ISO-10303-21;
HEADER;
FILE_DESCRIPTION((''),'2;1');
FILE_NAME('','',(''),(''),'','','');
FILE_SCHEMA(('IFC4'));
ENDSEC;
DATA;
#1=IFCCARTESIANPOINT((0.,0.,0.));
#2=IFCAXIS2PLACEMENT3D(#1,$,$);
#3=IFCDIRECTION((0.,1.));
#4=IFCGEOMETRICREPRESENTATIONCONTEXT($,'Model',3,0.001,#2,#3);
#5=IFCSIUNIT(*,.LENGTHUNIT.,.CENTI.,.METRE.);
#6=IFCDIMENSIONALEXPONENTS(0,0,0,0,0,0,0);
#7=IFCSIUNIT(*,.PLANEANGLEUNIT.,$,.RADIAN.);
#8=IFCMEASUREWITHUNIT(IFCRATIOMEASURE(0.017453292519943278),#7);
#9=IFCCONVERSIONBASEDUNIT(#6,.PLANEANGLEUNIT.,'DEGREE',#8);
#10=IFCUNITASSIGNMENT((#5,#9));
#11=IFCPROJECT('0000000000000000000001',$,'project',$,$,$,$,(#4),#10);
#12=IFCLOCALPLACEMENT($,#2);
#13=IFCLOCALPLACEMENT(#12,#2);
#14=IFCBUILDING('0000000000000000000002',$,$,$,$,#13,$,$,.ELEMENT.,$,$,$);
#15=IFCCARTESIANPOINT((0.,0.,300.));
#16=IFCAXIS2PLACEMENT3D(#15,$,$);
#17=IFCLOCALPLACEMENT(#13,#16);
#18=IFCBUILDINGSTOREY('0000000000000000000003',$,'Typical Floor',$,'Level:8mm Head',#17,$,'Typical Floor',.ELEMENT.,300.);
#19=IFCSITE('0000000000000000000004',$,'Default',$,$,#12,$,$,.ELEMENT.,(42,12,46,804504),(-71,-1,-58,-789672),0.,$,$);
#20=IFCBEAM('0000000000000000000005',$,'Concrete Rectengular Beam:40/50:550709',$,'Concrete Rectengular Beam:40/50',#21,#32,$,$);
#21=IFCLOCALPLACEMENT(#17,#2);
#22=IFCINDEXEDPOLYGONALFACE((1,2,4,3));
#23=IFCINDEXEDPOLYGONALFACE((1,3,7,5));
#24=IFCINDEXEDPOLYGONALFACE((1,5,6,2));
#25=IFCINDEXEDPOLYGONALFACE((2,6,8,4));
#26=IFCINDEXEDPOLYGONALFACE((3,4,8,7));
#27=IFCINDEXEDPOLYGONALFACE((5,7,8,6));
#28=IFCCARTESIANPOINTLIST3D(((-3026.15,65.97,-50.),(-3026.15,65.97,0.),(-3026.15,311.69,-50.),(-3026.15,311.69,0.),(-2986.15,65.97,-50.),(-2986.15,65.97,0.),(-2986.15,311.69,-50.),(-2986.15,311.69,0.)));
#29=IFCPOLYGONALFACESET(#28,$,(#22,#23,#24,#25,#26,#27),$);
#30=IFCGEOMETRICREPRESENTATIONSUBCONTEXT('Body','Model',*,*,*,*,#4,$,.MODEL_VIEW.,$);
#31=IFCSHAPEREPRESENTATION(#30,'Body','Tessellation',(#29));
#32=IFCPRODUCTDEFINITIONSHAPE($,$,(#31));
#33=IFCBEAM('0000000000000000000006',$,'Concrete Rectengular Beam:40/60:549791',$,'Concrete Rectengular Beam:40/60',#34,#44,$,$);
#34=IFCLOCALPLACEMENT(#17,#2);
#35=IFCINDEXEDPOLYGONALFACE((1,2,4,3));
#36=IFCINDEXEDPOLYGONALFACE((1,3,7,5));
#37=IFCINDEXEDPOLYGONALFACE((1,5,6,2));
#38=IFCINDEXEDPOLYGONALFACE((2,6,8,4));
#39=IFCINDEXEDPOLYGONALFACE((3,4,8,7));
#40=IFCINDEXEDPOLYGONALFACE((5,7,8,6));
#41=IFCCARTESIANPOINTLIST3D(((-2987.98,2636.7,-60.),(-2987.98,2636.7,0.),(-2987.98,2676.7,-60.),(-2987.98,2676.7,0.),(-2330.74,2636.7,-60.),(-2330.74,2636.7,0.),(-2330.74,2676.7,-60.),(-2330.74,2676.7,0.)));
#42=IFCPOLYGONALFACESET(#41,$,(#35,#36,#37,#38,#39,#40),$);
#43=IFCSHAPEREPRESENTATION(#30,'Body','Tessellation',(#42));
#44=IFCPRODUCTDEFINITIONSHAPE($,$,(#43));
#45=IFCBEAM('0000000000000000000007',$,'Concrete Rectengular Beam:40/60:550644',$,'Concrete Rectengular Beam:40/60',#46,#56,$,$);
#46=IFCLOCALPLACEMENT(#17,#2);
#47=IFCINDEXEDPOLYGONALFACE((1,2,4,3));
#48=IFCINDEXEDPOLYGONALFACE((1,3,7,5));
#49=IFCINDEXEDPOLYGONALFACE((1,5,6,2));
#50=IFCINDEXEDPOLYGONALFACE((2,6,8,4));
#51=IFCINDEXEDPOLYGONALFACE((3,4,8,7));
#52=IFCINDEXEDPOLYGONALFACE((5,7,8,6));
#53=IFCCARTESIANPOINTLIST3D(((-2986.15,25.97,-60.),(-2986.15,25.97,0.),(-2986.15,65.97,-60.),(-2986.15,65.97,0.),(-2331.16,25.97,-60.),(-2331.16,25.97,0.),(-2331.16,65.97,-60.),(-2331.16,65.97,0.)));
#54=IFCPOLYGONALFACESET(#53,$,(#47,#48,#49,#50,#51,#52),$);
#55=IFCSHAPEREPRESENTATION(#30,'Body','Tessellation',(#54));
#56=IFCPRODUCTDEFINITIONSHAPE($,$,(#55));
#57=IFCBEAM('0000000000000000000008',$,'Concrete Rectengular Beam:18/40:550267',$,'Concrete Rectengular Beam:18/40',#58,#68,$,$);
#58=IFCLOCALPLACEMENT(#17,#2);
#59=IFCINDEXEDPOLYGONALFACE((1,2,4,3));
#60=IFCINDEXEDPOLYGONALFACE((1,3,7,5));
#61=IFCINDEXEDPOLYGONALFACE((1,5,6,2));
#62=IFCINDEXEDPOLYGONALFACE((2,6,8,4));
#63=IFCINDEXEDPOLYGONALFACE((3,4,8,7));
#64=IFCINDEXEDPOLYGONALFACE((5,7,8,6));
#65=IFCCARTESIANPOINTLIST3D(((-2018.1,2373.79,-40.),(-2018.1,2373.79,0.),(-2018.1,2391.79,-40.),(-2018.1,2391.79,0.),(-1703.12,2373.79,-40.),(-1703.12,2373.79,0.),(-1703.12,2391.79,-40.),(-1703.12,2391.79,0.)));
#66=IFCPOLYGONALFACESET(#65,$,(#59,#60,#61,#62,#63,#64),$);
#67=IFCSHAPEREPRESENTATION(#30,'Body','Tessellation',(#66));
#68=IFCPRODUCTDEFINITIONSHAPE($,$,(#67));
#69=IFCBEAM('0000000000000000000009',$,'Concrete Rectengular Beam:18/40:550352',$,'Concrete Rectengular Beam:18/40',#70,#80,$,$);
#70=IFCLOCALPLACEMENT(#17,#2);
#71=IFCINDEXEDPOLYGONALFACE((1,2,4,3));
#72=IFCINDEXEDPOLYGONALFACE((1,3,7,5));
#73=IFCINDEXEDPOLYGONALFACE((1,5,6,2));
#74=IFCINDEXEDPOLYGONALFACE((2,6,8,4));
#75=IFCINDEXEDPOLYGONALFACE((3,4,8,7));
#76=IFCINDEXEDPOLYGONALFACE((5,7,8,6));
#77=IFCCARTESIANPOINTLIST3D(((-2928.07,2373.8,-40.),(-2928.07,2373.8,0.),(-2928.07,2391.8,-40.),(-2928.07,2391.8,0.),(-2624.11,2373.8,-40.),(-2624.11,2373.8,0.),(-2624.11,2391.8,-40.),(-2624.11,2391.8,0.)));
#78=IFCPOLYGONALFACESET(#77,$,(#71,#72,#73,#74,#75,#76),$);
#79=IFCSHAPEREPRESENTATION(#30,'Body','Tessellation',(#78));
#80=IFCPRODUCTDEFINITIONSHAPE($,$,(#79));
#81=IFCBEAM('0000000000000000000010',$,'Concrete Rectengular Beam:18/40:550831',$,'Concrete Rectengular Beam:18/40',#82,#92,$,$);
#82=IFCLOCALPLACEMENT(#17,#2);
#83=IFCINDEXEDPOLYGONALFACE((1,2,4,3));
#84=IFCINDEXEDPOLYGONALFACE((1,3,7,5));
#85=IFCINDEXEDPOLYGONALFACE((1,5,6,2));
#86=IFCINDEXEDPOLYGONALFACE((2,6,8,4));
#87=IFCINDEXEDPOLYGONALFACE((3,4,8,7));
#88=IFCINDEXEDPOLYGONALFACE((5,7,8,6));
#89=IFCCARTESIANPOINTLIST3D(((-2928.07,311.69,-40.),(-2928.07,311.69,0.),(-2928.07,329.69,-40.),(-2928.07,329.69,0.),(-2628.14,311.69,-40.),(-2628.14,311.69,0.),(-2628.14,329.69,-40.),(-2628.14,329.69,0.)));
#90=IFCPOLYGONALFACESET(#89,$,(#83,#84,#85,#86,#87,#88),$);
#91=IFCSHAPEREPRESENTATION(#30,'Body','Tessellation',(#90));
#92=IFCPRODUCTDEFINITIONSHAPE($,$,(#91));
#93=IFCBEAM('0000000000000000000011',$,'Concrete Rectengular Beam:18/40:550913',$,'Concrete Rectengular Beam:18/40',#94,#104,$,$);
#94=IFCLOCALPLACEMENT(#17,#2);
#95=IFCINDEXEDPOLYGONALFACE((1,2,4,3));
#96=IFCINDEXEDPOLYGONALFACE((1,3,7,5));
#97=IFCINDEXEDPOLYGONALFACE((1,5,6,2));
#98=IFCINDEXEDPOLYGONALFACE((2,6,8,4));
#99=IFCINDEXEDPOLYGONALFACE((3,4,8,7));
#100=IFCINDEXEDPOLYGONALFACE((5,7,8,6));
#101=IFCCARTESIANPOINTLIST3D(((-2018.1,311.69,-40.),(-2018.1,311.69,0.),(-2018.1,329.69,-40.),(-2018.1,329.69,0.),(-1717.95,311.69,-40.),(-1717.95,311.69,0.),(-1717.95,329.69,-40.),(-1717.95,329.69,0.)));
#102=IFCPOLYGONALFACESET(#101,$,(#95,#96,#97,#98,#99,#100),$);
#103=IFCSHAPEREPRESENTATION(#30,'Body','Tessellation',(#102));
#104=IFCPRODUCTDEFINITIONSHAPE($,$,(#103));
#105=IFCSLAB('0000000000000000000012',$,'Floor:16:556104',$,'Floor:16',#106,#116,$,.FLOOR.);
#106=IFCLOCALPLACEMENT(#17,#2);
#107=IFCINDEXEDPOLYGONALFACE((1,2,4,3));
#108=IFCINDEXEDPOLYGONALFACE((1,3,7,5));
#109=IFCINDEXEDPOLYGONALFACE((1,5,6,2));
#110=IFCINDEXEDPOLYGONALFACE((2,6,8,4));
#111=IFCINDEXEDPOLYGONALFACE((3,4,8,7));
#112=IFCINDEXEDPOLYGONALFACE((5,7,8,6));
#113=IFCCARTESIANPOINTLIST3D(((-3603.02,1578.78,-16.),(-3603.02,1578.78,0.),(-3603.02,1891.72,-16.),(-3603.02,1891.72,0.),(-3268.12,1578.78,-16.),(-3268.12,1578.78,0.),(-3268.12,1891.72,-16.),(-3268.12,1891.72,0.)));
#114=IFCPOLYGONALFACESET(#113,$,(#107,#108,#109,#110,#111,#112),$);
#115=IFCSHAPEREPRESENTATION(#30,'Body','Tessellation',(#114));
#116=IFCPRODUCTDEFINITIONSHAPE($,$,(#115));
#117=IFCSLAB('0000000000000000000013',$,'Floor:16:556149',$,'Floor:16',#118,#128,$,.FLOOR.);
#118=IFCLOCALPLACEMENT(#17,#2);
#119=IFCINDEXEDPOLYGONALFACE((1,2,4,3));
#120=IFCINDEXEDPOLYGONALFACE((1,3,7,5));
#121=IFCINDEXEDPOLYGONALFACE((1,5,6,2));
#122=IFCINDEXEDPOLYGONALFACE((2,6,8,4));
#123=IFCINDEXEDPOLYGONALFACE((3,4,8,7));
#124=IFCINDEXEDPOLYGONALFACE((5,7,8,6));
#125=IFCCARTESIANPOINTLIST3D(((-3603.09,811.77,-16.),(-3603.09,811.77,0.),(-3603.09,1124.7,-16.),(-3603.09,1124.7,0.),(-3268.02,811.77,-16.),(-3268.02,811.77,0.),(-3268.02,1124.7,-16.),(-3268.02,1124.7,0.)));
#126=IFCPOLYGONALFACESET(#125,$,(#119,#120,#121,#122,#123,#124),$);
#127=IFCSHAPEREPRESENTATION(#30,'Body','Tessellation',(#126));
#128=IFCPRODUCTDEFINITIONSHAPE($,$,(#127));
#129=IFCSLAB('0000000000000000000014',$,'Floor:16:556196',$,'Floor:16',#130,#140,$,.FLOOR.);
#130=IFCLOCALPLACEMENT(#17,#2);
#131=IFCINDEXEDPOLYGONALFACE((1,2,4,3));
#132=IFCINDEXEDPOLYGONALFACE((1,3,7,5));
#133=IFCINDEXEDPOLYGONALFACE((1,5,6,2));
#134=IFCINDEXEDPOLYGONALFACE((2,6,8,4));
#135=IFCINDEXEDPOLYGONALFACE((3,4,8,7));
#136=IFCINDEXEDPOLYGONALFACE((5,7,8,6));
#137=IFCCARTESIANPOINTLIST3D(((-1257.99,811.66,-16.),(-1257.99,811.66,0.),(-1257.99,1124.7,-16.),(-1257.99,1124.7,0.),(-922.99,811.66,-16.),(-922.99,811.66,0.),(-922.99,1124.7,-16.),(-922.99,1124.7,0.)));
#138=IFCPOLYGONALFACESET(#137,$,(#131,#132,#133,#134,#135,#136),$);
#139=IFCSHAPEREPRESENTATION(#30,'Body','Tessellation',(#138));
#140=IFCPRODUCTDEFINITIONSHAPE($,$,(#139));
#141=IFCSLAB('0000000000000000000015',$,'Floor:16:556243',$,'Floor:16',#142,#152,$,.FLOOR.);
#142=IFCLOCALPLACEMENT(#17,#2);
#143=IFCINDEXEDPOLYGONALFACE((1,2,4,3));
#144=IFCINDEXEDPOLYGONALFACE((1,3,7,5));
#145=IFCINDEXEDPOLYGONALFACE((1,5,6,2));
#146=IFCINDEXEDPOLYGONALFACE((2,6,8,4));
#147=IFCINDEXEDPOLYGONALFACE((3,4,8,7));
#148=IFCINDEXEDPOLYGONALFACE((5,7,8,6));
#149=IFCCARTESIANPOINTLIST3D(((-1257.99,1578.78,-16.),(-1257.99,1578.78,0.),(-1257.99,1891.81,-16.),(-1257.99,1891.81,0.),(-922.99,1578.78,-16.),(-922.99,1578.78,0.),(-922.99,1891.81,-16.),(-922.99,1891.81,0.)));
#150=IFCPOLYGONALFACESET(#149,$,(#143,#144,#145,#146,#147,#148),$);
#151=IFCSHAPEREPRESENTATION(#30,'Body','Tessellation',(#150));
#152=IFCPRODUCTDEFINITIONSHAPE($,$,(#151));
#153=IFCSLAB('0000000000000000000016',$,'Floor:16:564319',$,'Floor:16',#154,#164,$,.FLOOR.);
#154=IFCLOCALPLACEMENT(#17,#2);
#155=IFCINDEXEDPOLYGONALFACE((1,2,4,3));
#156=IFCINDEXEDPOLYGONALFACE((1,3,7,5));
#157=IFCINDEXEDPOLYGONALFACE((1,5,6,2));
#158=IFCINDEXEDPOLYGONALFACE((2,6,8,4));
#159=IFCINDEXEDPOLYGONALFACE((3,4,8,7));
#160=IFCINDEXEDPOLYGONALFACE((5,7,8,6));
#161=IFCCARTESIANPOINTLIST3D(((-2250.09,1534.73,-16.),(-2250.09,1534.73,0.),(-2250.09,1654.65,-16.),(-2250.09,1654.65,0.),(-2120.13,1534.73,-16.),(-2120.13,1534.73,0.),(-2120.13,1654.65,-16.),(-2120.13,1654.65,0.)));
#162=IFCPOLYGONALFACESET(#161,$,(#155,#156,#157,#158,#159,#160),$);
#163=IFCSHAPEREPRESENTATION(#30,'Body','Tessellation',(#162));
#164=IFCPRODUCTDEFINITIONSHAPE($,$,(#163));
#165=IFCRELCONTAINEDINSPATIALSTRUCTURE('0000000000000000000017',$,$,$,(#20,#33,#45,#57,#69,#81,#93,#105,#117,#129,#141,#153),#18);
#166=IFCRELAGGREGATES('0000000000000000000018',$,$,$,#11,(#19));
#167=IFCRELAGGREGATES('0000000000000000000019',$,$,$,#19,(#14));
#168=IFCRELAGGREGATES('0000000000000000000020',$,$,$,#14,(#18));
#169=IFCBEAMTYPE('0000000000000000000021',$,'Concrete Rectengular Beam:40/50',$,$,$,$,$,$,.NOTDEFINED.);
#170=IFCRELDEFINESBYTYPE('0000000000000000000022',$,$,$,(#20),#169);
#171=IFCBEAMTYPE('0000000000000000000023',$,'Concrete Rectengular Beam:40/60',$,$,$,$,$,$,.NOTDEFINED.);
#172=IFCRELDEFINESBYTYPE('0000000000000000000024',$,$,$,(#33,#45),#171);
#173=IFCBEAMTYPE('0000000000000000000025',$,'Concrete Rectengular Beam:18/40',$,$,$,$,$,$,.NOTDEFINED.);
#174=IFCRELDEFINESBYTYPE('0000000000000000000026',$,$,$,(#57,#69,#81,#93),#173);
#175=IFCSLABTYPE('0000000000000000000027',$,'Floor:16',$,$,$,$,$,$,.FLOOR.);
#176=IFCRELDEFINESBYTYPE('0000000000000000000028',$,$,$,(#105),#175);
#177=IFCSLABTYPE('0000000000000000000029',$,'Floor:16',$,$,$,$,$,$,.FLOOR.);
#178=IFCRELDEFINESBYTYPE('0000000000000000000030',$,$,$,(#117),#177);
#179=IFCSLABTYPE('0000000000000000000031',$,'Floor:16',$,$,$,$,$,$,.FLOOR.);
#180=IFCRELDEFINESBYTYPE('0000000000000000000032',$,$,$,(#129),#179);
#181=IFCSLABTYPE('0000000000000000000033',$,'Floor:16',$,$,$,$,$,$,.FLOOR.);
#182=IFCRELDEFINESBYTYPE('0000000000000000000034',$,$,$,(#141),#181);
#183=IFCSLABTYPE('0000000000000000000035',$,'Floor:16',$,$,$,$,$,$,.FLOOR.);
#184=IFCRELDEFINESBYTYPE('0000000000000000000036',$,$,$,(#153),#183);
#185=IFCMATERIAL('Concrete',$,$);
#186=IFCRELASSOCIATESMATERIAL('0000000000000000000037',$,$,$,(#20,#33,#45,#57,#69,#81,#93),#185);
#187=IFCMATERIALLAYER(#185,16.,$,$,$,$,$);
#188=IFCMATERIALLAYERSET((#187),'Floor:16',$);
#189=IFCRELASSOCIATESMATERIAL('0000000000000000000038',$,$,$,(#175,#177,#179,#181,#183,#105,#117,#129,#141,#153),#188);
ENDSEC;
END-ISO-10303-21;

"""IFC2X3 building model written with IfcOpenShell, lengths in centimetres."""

from ifc_helpers import new_model, entity, si_unit, converted_unit, direction, frame, frame_2d, origin, origin_2d_with_axis, place, context, subcontext, project, spatial, rectangle, extrude, material, layer, layer_set, layer_usage, type_object, element, save


model = new_model("IFC2X3")

# Units and contexts
model_context = context("Model", 3, precision=0.001, world=origin(), true_north=direction((0.0, 1.0)))
body_context = subcontext(model_context, "Body", "Model", "MODEL_VIEW")
ifc_project = project(units=[si_unit("LENGTHUNIT", "METRE", prefix="CENTI"), converted_unit("PLANEANGLEUNIT", "DEGREE", entity("IfcRatioMeasure", 0.017453292519943278), si_unit("PLANEANGLEUNIT", "RADIAN"), dimensions=[0, 0, 0, 0, 0, 0, 0])], contexts=[model_context])

# Site, building, storey
site_placement = place(None, origin())
site = spatial("IfcSite", under=ifc_project, at=site_placement, Name="Default", CompositionType="ELEMENT", RefLatitude=(42, 12, 46, 804504), RefLongitude=(-71, -1, -58, -789672), RefElevation=0.0)
building_placement = place(site_placement, origin())
building = spatial("IfcBuilding", under=site, at=building_placement, CompositionType="ELEMENT")
storey_placement = place(building_placement, frame((0.0, 0.0, 300.0)))
storey = spatial("IfcBuildingStorey", under=building, at=storey_placement, Name="Typical Floor", ObjectType="Level:8mm Head", LongName="Typical Floor", CompositionType="ELEMENT", Elevation=300.0)

# Beams
ifc_material = material(Name="Concrete")
beam_type_1 = type_object("IfcBeamType", Name="Concrete Rectengular Beam:40/50", PredefinedType="NOTDEFINED")
beam_1_placement = place(storey_placement, frame((-3006.15, 45.97, 0.0), z_axis=(0.0, 0.0, 1.0), x_axis=(0.0, 1.0, 0.0)))
element("IfcBeam", 1, at=beam_1_placement, inside=storey, type_object=beam_type_1, material=ifc_material, Name="Concrete Rectengular Beam:40/50:550709", ObjectType="Concrete Rectengular Beam:40/50", context=body_context, shape_type="SweptSolid", body=[
    extrude(rectangle(XDim=50.0, YDim=40.0, at=origin_2d_with_axis()), frame((20.0, 0.0, -25.0), z_axis=(1.0, 0.0, 0.0), x_axis=(0.0, 0.0, -1.0)), (0.0, 0.0, 1.0), 245.72),
])
beam_type_2 = type_object("IfcBeamType", Name="Concrete Rectengular Beam:40/60", PredefinedType="NOTDEFINED")
beam_2_placement = place(storey_placement, frame((-3007.98, 2656.7, 0.0)))
element("IfcBeam", 2, at=beam_2_placement, inside=storey, type_object=beam_type_2, material=ifc_material, Name="Concrete Rectengular Beam:40/60:549791", ObjectType="Concrete Rectengular Beam:40/60", context=body_context, shape_type="SweptSolid", body=[
    extrude(rectangle(XDim=60.0, YDim=40.0, at=frame_2d((0.0, 0.0), x_axis=(1.0, 0.0))), frame((20.0, 0.0, -30.0), z_axis=(1.0, 0.0, 0.0), x_axis=(0.0, 0.0, -1.0)), (0.0, 0.0, 1.0), 657.24),
])
beam_3_placement = place(storey_placement, frame((-3006.15, 45.97, 0.0)))
element("IfcBeam", 3, at=beam_3_placement, inside=storey, type_object=beam_type_2, material=ifc_material, Name="Concrete Rectengular Beam:40/60:550644", ObjectType="Concrete Rectengular Beam:40/60", context=body_context, shape_type="SweptSolid", body=[
    extrude(rectangle(XDim=60.0, YDim=40.0, at=frame_2d((0.0, 0.0), x_axis=(1.0, 0.0))), frame((20.0, 0.0, -30.0), z_axis=(1.0, 0.0, 0.0), x_axis=(0.0, 0.0, -1.0)), (0.0, 0.0, 1.0), 654.99),
])
beam_type_3 = type_object("IfcBeamType", Name="Concrete Rectengular Beam:18/40", PredefinedType="NOTDEFINED")
beam_4_placement = place(storey_placement, frame((-2018.1, 2382.79, 0.0)))
element("IfcBeam", 4, at=beam_4_placement, inside=storey, type_object=beam_type_3, material=ifc_material, Name="Concrete Rectengular Beam:18/40:550267", ObjectType="Concrete Rectengular Beam:18/40", context=body_context, shape_type="SweptSolid", body=[
    extrude(rectangle(XDim=40.0, YDim=18.0, at=frame_2d((0.0, 0.0), x_axis=(1.0, 0.0))), frame((0.0, 0.0, -20.0), z_axis=(1.0, 0.0, 0.0), x_axis=(0.0, 0.0, -1.0)), (0.0, 0.0, 1.0), 314.98),
])
beam_5_placement = place(storey_placement, frame((-2928.07, 2382.8, 0.0)))
element("IfcBeam", 5, at=beam_5_placement, inside=storey, type_object=beam_type_3, material=ifc_material, Name="Concrete Rectengular Beam:18/40:550352", ObjectType="Concrete Rectengular Beam:18/40", context=body_context, shape_type="SweptSolid", body=[
    extrude(rectangle(XDim=40.0, YDim=18.0, at=frame_2d((0.0, 0.0), x_axis=(1.0, 0.0))), frame((0.0, 0.0, -20.0), z_axis=(1.0, 0.0, 0.0), x_axis=(0.0, 0.0, -1.0)), (0.0, 0.0, 1.0), 303.96),
])
beam_6_placement = place(storey_placement, frame((-2928.07, 320.69, 0.0)))
element("IfcBeam", 6, at=beam_6_placement, inside=storey, type_object=beam_type_3, material=ifc_material, Name="Concrete Rectengular Beam:18/40:550831", ObjectType="Concrete Rectengular Beam:18/40", context=body_context, shape_type="SweptSolid", body=[
    extrude(rectangle(XDim=40.0, YDim=18.0, at=frame_2d((0.0, 0.0), x_axis=(1.0, 0.0))), frame((0.0, 0.0, -20.0), z_axis=(1.0, 0.0, 0.0), x_axis=(0.0, 0.0, -1.0)), (0.0, 0.0, 1.0), 299.94),
])
beam_7_placement = place(storey_placement, frame((-2018.1, 320.69, 0.0)))
element("IfcBeam", 7, at=beam_7_placement, inside=storey, type_object=beam_type_3, material=ifc_material, Name="Concrete Rectengular Beam:18/40:550913", ObjectType="Concrete Rectengular Beam:18/40", context=body_context, shape_type="SweptSolid", body=[
    extrude(rectangle(XDim=40.0, YDim=18.0, at=frame_2d((0.0, 0.0), x_axis=(1.0, 0.0))), frame((0.0, 0.0, -20.0), z_axis=(1.0, 0.0, 0.0), x_axis=(0.0, 0.0, -1.0)), (0.0, 0.0, 1.0), 300.15),
])

# Slabs
ifc_layer = layer(ifc_material, 16.0)
ifc_layer_set = layer_set([ifc_layer], Name="Floor:16")
ifc_layer_usage_1 = layer_usage(ifc_layer_set, "AXIS3", "POSITIVE", 0.0)
slab_type_1 = type_object("IfcSlabType", Name="Floor:16", PredefinedType="FLOOR", material=ifc_layer_set)
slab_1_placement = place(storey_placement, origin())
element("IfcSlab", 8, at=slab_1_placement, inside=storey, type_object=slab_type_1, material=ifc_layer_usage_1, Name="Floor:16:556104", ObjectType="Floor:16", PredefinedType="FLOOR", context=body_context, shape_type="SweptSolid", body=[
    extrude(rectangle(XDim=312.94, YDim=334.9, at=frame_2d((0.0, 0.0), x_axis=(1.0, 0.0))), frame((-3435.57, 1735.25, 0.0), z_axis=(0.0, 0.0, -1.0), x_axis=(0.0, 1.0, 0.0)), (0.0, 0.0, 1.0), 16.0),
])
ifc_layer_usage_2 = layer_usage(ifc_layer_set, "AXIS3", "POSITIVE", 0.0)
slab_type_2 = type_object("IfcSlabType", Name="Floor:16", PredefinedType="FLOOR", material=ifc_layer_set)
slab_2_placement = place(storey_placement, origin())
element("IfcSlab", 9, at=slab_2_placement, inside=storey, type_object=slab_type_2, material=ifc_layer_usage_2, Name="Floor:16:556149", ObjectType="Floor:16", PredefinedType="FLOOR", context=body_context, shape_type="SweptSolid", body=[
    extrude(rectangle(XDim=312.94, YDim=335.08, at=origin_2d_with_axis()), frame((-3435.56, 968.24, 0.0), z_axis=(0.0, 0.0, -1.0), x_axis=(0.0, 1.0, 0.0)), (0.0, 0.0, 1.0), 16.0),
])
ifc_layer_usage_3 = layer_usage(ifc_layer_set, "AXIS3", "POSITIVE", 0.0)
slab_type_3 = type_object("IfcSlabType", Name="Floor:16", PredefinedType="FLOOR", material=ifc_layer_set)
slab_3_placement = place(storey_placement, origin())
element("IfcSlab", 10, at=slab_3_placement, inside=storey, type_object=slab_type_3, material=ifc_layer_usage_3, Name="Floor:16:556196", ObjectType="Floor:16", PredefinedType="FLOOR", context=body_context, shape_type="SweptSolid", body=[
    extrude(rectangle(XDim=313.04, YDim=335.0, at=frame_2d((0.0, 0.0), x_axis=(1.0, 0.0))), frame((-1090.49, 968.18, 0.0), z_axis=(0.0, 0.0, -1.0), x_axis=(0.0, 1.0, 0.0)), (0.0, 0.0, 1.0), 16.0),
])
ifc_layer_usage_4 = layer_usage(ifc_layer_set, "AXIS3", "POSITIVE", 0.0)
slab_type_4 = type_object("IfcSlabType", Name="Floor:16", PredefinedType="FLOOR", material=ifc_layer_set)
slab_4_placement = place(storey_placement, origin())
element("IfcSlab", 11, at=slab_4_placement, inside=storey, type_object=slab_type_4, material=ifc_layer_usage_4, Name="Floor:16:556243", ObjectType="Floor:16", PredefinedType="FLOOR", context=body_context, shape_type="SweptSolid", body=[
    extrude(rectangle(XDim=313.04, YDim=335.0, at=frame_2d((0.0, 0.0), x_axis=(1.0, 0.0))), frame((-1090.49, 1735.29, 0.0), z_axis=(0.0, 0.0, -1.0), x_axis=(0.0, 1.0, 0.0)), (0.0, 0.0, 1.0), 16.0),
])
ifc_layer_usage_5 = layer_usage(ifc_layer_set, "AXIS3", "POSITIVE", 0.0)
slab_type_5 = type_object("IfcSlabType", Name="Floor:16", PredefinedType="FLOOR", material=ifc_layer_set)
slab_5_placement = place(storey_placement, origin())
element("IfcSlab", 12, at=slab_5_placement, inside=storey, type_object=slab_type_5, material=ifc_layer_usage_5, Name="Floor:16:564319", ObjectType="Floor:16", PredefinedType="FLOOR", context=body_context, shape_type="SweptSolid", body=[
    extrude(rectangle(XDim=119.91, YDim=129.97, at=frame_2d((0.0, 0.0), x_axis=(1.0, 0.0))), frame((-2185.11, 1594.69, 0.0), z_axis=(0.0, 0.0, -1.0), x_axis=(0.0, 1.0, 0.0)), (0.0, 0.0, 1.0), 16.0),
])

save(model, "model.ifc")
